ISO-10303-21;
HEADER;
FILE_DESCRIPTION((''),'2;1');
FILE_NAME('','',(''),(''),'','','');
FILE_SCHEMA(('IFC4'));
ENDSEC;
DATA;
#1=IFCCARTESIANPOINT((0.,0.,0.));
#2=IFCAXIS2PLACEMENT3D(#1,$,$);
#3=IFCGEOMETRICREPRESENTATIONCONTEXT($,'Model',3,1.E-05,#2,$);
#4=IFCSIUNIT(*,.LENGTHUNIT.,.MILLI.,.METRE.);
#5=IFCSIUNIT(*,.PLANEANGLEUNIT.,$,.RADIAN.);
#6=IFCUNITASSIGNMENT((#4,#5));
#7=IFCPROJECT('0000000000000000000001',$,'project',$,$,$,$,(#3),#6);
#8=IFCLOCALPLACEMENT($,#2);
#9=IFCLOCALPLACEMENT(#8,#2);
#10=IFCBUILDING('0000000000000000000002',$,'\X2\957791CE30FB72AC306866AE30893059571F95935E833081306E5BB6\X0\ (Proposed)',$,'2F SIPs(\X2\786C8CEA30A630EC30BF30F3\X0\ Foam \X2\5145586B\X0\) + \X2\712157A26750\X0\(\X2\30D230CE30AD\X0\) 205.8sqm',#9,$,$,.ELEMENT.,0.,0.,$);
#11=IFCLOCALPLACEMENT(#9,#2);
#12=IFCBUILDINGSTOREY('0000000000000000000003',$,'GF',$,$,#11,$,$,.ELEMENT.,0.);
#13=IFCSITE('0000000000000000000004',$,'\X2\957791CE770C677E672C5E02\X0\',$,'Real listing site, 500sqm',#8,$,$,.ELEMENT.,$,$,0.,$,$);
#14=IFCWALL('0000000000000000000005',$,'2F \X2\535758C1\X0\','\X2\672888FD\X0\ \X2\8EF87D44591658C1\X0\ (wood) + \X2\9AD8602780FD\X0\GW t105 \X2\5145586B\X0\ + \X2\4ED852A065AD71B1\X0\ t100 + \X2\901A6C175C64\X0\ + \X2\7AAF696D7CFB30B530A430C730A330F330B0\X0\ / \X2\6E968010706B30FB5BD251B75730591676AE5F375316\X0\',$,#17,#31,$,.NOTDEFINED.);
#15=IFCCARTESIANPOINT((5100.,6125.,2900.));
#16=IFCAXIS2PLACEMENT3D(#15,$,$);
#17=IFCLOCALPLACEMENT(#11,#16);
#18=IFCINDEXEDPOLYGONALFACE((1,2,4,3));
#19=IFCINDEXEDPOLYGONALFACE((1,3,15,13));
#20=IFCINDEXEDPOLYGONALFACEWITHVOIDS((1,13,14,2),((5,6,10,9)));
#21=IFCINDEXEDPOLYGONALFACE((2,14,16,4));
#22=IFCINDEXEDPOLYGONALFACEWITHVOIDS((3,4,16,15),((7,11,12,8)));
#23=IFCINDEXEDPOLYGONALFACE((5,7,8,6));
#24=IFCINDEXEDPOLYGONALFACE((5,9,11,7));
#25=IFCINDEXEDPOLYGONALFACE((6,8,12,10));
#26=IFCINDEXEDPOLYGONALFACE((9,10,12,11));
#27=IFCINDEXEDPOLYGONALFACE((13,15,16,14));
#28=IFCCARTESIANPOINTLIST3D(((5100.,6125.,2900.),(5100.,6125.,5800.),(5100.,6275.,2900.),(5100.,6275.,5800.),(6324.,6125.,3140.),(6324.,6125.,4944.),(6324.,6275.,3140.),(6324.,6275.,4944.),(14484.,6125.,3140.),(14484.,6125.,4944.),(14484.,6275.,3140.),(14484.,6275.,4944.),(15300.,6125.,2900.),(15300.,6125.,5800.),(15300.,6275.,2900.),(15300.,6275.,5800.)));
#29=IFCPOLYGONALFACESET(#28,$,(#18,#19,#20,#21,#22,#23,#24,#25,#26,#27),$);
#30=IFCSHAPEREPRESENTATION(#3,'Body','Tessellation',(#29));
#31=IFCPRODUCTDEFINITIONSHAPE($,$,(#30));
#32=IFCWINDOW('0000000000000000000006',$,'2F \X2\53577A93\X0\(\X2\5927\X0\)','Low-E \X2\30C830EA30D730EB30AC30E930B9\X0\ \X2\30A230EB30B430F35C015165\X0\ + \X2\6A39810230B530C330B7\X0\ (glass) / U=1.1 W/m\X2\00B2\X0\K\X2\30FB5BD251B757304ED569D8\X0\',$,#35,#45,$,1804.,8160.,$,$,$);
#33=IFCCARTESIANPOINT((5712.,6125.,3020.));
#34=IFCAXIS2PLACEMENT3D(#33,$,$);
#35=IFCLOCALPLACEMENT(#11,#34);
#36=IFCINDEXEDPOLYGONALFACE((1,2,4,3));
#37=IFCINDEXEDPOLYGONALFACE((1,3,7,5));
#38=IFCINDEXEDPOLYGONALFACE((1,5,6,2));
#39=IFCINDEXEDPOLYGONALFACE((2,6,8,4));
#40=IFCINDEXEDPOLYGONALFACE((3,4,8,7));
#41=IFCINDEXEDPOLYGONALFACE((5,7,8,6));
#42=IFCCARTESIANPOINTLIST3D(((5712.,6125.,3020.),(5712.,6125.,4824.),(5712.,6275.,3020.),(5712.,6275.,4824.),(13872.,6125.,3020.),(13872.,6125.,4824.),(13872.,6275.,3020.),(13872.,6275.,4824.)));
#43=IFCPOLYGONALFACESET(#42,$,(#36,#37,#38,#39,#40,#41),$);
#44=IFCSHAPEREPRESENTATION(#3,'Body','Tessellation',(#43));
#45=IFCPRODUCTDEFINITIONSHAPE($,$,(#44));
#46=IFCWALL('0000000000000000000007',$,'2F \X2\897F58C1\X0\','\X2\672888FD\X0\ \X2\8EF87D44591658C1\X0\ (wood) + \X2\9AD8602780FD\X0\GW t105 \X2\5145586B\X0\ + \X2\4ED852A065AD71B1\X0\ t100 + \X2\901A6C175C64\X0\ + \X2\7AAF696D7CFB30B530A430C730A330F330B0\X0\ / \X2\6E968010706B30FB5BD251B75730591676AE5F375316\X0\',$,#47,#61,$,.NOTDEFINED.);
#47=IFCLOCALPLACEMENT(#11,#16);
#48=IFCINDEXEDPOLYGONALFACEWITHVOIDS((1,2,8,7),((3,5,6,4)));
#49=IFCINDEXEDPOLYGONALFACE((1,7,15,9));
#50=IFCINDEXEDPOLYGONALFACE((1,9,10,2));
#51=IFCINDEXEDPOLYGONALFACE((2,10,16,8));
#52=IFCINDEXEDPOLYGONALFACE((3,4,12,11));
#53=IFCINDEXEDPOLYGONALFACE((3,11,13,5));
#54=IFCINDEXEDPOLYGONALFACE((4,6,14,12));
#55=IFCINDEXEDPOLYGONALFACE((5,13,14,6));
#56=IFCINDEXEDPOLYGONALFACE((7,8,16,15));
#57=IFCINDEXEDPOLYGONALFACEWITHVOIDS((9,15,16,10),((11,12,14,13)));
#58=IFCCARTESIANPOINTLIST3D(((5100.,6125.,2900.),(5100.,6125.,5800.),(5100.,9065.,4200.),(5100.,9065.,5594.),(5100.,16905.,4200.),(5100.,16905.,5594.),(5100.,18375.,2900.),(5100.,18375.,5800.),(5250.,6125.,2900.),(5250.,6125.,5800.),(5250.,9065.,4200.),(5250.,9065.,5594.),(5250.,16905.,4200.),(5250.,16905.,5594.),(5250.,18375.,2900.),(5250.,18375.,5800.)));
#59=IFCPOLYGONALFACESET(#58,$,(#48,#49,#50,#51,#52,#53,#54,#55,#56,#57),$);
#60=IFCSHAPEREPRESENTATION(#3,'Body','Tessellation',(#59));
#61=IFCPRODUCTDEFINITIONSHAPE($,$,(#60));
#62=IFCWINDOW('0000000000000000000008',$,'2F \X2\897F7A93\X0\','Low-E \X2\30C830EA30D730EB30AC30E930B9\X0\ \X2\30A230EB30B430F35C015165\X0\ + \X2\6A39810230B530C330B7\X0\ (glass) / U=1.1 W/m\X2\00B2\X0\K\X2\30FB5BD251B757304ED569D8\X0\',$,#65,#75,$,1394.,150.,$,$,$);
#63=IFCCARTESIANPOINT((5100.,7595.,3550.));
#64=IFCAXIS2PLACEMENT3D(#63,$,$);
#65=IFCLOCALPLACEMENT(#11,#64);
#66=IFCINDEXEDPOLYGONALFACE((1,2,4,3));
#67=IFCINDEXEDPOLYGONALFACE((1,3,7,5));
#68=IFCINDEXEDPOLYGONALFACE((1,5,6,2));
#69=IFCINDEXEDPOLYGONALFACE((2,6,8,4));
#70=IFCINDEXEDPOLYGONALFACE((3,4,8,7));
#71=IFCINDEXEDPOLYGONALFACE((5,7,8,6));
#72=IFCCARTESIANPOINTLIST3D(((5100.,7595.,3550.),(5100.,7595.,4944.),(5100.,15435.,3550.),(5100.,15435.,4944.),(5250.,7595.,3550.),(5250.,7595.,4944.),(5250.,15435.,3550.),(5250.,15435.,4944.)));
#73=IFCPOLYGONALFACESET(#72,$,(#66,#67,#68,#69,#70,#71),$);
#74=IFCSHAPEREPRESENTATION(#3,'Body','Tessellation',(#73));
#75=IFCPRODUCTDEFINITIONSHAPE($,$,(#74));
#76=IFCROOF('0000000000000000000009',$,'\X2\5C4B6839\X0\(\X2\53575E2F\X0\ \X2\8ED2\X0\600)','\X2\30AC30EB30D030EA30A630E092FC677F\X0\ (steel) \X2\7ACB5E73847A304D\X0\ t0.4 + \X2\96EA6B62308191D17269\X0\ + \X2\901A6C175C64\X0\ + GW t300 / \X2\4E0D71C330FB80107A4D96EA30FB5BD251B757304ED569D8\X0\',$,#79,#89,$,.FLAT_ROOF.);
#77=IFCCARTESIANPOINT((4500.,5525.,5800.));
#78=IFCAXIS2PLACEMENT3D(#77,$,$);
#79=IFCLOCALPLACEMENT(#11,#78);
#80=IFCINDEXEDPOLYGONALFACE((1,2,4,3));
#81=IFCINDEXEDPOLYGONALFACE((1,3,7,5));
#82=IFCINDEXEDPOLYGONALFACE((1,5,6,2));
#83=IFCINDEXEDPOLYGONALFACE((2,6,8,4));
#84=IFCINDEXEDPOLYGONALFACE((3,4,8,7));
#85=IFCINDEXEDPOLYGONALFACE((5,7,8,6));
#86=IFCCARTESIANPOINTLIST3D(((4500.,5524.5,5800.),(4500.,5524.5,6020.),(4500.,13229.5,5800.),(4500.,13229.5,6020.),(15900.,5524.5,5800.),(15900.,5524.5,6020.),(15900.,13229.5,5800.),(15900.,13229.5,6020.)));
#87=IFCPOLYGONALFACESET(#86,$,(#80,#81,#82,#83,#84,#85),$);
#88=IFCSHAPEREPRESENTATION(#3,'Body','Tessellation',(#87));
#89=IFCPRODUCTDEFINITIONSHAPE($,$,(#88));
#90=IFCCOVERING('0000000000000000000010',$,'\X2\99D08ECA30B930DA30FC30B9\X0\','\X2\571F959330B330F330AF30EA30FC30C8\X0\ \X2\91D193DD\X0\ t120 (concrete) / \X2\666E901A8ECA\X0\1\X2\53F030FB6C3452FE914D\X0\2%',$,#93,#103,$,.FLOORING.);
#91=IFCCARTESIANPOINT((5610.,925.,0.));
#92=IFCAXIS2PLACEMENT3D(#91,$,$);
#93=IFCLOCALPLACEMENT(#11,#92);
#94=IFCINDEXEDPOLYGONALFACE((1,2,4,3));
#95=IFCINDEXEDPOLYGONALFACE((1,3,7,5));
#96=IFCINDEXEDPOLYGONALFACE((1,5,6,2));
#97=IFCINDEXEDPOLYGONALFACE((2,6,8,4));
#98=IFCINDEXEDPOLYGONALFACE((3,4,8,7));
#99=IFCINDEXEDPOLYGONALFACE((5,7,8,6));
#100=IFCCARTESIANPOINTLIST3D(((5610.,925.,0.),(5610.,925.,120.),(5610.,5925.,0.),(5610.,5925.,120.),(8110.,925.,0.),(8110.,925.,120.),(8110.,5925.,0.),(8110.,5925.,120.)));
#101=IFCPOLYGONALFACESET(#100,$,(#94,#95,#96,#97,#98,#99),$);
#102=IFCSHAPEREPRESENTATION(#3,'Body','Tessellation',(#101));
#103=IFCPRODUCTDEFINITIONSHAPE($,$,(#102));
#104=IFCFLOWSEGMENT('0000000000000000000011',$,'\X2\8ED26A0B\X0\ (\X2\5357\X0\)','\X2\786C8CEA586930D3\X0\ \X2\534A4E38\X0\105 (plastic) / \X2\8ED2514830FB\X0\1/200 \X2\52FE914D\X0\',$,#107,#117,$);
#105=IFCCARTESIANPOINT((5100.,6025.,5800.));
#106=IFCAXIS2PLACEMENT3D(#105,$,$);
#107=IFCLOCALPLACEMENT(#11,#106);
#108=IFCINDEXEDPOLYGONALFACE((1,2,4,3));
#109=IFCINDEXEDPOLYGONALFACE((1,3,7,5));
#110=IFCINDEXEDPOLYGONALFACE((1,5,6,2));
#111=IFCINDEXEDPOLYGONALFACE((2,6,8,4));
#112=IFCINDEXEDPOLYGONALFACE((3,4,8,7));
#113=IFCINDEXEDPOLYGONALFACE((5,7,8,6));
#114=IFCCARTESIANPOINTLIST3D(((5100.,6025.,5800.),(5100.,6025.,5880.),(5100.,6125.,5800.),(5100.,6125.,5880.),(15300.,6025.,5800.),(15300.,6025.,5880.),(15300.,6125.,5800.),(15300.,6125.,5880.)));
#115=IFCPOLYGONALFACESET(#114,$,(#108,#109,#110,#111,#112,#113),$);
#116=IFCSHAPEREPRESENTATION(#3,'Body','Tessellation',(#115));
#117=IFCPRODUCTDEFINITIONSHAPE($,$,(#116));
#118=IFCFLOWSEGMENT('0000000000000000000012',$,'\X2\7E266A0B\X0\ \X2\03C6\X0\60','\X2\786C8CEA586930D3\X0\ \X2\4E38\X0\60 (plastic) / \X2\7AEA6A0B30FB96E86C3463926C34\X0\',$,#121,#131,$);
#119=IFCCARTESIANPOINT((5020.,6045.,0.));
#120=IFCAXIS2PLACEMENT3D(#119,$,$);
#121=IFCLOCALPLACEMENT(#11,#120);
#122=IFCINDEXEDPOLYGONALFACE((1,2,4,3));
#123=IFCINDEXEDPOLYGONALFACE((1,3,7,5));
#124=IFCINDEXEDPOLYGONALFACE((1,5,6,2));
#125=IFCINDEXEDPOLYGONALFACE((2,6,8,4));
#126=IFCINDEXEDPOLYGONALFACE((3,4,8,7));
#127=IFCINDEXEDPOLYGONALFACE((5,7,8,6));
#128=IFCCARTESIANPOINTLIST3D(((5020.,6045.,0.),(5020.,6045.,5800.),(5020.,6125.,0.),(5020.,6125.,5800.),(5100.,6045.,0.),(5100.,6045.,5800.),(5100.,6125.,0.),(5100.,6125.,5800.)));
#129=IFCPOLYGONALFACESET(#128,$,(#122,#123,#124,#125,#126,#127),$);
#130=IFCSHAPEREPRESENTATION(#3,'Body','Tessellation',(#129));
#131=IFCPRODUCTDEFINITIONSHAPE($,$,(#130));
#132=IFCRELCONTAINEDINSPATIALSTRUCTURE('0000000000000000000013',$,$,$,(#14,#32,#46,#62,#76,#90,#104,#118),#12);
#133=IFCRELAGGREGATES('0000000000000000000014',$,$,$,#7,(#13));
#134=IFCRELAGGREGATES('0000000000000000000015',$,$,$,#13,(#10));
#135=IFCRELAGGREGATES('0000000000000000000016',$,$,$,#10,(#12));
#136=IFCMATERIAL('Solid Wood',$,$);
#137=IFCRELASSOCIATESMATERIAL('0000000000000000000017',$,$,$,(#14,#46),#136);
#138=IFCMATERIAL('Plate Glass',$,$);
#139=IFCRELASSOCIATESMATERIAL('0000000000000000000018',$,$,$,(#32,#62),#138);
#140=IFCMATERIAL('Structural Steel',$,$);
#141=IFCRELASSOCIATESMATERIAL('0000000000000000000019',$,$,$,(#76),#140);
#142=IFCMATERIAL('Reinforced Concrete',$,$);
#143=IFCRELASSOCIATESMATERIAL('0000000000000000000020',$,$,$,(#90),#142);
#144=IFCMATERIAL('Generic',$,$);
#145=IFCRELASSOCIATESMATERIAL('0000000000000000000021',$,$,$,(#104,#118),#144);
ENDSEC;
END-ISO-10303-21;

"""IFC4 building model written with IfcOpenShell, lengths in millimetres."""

from ifc_helpers import new_model, si_unit, frame, frame_2d, origin, place, context, project, spatial, rectangle, extrude, material, element, fill, save


model = new_model("IFC4")

# Units and contexts
model_context = context("Model", 3, precision=1e-05, world=origin())
ifc_project = project(units=[si_unit("LENGTHUNIT", "METRE", prefix="MILLI"), si_unit("PLANEANGLEUNIT", "RADIAN")], contexts=[model_context])

# Site, building, storey
site_placement = place(None, origin())
site = spatial("IfcSite", under=ifc_project, at=site_placement, Name="長野県松本市", ObjectType="Real listing site, 500sqm", CompositionType="ELEMENT", RefElevation=0.0)
building_placement = place(site_placement, origin())
building = spatial("IfcBuilding", under=site, at=building_placement, Name="長野・犬と暮らす土間広めの家 (Proposed)", ObjectType="2F SIPs(硬質ウレタン Foam 充填) + 無垢材(ヒノキ) 205.8sqm", CompositionType="ELEMENT", ElevationOfRefHeight=0.0, ElevationOfTerrain=0.0)
storey_placement = place(building_placement, origin())
storey = spatial("IfcBuildingStorey", under=building, at=storey_placement, Name="GF", CompositionType="ELEMENT", Elevation=0.0)

# Shared definitions
ifc_material_1 = material(Name="Solid Wood")

# Shared definitions
ifc_material_2 = material(Name="Reinforced Concrete")

# Shared definitions
ifc_material_3 = material(Name="Plate Glass")

# Walls, openings, windows
wall_1_placement = place(storey_placement, frame((5100.0, 6125.0, 2900.0)))
wall_1 = element("IfcWall", 1, at=wall_1_placement, inside=storey, material=ifc_material_1, Name="2F 南壁", Description="木製 軸組外壁 (wood) + 高性能GW t105 充填 + 付加断熱 t100 + 通気層 + 窯業系サイディング / 準耐火・寒冷地外皮強化", PredefinedType="NOTDEFINED", context=model_context, shape_type="SweptSolid", body=[
    extrude(rectangle(XDim=10200.0, YDim=150.0, at=frame_2d((5100.0, 75.0))), frame((5100.0, 6125.0, 2900.0)), (0.0, 0.0, 1.0), 2900.0),
])
opening_1_placement = place(storey_placement, frame((5712.0, 6125.0, 3020.0)))
opening_1 = element("IfcOpeningElement", 2, at=opening_1_placement, cuts=wall_1, PredefinedType="NOTDEFINED", context=model_context, shape_type="SweptSolid", body=[
    extrude(rectangle(XDim=8160.0, YDim=150.0, at=frame_2d((4080.0, 75.0))), frame((5712.0, 6125.0, 3020.0)), (0.0, 0.0, 1.0), 1804.0),
])
window_1_placement = place(storey_placement, frame((5712.0, 6125.0, 3020.0)))
window_1 = element("IfcWindow", 3, at=window_1_placement, inside=storey, material=ifc_material_3, Name="2F 南窓(大)", Description="Low-E トリプルガラス アルゴン封入 + 樹脂サッシ (glass) / U=1.1 W/m²K・寒冷地仕様", OverallHeight=1804.0, OverallWidth=8160.0, context=model_context, shape_type="SweptSolid", body=[
    extrude(rectangle(XDim=8160.0, YDim=150.0, at=frame_2d((4080.0, 75.0))), frame((5712.0, 6125.0, 3020.0)), (0.0, 0.0, 1.0), 1804.0),
])
fill(opening_1, window_1)
wall_2_placement = place(storey_placement, frame((5100.0, 6125.0, 2900.0)))
wall_2 = element("IfcWall", 4, at=wall_2_placement, inside=storey, material=ifc_material_1, Name="2F 西壁", Description="木製 軸組外壁 (wood) + 高性能GW t105 充填 + 付加断熱 t100 + 通気層 + 窯業系サイディング / 準耐火・寒冷地外皮強化", PredefinedType="NOTDEFINED", context=model_context, shape_type="SweptSolid", body=[
    extrude(rectangle(XDim=150.0, YDim=12250.0, at=frame_2d((75.0, 6125.0))), frame((5100.0, 6125.0, 2900.0)), (0.0, 0.0, 1.0), 2900.0),
])
opening_2_placement = place(storey_placement, frame((5100.0, 7595.0, 3550.0)))
opening_2 = element("IfcOpeningElement", 5, at=opening_2_placement, cuts=wall_2, PredefinedType="NOTDEFINED", context=model_context, shape_type="SweptSolid", body=[
    extrude(rectangle(XDim=150.0, YDim=7840.0, at=frame_2d((75.0, 3920.0))), frame((5100.0, 7595.0, 3550.0)), (0.0, 0.0, 1.0), 1394.0),
])
window_2_placement = place(storey_placement, frame((5100.0, 7595.0, 3550.0)))
window_2 = element("IfcWindow", 6, at=window_2_placement, inside=storey, material=ifc_material_3, Name="2F 西窓", Description="Low-E トリプルガラス アルゴン封入 + 樹脂サッシ (glass) / U=1.1 W/m²K・寒冷地仕様", OverallHeight=1394.0, OverallWidth=150.0, context=model_context, shape_type="SweptSolid", body=[
    extrude(rectangle(XDim=150.0, YDim=7840.0, at=frame_2d((75.0, 3920.0))), frame((5100.0, 7595.0, 3550.0)), (0.0, 0.0, 1.0), 1394.0),
])
fill(opening_2, window_2)

# Roof
ifc_material_4 = material(Name="Structural Steel")
for number, where, name in (
    (7, (4500.0, 5525.0, 5800.0), "屋根(南帯 軒600)"),
):
    element("IfcRoof", number, at=place(storey_placement, frame(where)), inside=storey, material=ifc_material_4, Name=name, Description="ガルバリウム鋼板 (steel) 立平葺き t0.4 + 雪止め金物 + 通気層 + GW t300 / 不燃・耐積雪・寒冷地仕様", PredefinedType="FLAT_ROOF", context=model_context, shape_type="SweptSolid", body=[
        extrude(rectangle(XDim=11400.0, YDim=7705.0, at=frame_2d((5700.0, 3852.0))), frame((4500.0, 5525.0, 5800.0)), (0.0, 0.0, 1.0), 220.0),
    ])

# Covering
covering_placement = place(storey_placement, frame((5610.0, 925.0, 0.0)))
element("IfcCovering", 8, at=covering_placement, inside=storey, material=ifc_material_2, Name="駐車スペース", Description="土間コンクリート 金鏝 t120 (concrete) / 普通車1台・水勾配2%", PredefinedType="FLOORING", context=model_context, shape_type="SweptSolid", body=[
    extrude(rectangle(XDim=2500.0, YDim=5000.0, at=frame_2d((1250.0, 2500.0))), frame((5610.0, 925.0, 0.0)), (0.0, 0.0, 1.0), 120.0),
])

# Flow segments
ifc_material_5 = material(Name="Generic")
flow_segment_1_placement = place(storey_placement, frame((5100.0, 6025.0, 5800.0)))
element("IfcFlowSegment", 9, at=flow_segment_1_placement, inside=storey, material=ifc_material_5, Name="軒樋 (南)", Description="硬質塩ビ 半丸105 (plastic) / 軒先・1/200 勾配", context=model_context, shape_type="SweptSolid", body=[
    extrude(rectangle(XDim=10200.0, YDim=100.0, at=frame_2d((5100.0, 50.0))), frame((5100.0, 6025.0, 5800.0)), (0.0, 0.0, 1.0), 80.0),
])
flow_segment_2_placement = place(storey_placement, frame((5020.0, 6045.0, 0.0)))
element("IfcFlowSegment", 10, at=flow_segment_2_placement, inside=storey, material=ifc_material_5, Name="縦樋 φ60", Description="硬質塩ビ 丸60 (plastic) / 竪樋・雨水排水", context=model_context, shape_type="SweptSolid", body=[
    extrude(rectangle(XDim=80.0, YDim=80.0, at=frame_2d((40.0, 40.0))), frame((5020.0, 6045.0, 0.0)), (0.0, 0.0, 1.0), 5800.0),
])

save(model, "model.ifc")
